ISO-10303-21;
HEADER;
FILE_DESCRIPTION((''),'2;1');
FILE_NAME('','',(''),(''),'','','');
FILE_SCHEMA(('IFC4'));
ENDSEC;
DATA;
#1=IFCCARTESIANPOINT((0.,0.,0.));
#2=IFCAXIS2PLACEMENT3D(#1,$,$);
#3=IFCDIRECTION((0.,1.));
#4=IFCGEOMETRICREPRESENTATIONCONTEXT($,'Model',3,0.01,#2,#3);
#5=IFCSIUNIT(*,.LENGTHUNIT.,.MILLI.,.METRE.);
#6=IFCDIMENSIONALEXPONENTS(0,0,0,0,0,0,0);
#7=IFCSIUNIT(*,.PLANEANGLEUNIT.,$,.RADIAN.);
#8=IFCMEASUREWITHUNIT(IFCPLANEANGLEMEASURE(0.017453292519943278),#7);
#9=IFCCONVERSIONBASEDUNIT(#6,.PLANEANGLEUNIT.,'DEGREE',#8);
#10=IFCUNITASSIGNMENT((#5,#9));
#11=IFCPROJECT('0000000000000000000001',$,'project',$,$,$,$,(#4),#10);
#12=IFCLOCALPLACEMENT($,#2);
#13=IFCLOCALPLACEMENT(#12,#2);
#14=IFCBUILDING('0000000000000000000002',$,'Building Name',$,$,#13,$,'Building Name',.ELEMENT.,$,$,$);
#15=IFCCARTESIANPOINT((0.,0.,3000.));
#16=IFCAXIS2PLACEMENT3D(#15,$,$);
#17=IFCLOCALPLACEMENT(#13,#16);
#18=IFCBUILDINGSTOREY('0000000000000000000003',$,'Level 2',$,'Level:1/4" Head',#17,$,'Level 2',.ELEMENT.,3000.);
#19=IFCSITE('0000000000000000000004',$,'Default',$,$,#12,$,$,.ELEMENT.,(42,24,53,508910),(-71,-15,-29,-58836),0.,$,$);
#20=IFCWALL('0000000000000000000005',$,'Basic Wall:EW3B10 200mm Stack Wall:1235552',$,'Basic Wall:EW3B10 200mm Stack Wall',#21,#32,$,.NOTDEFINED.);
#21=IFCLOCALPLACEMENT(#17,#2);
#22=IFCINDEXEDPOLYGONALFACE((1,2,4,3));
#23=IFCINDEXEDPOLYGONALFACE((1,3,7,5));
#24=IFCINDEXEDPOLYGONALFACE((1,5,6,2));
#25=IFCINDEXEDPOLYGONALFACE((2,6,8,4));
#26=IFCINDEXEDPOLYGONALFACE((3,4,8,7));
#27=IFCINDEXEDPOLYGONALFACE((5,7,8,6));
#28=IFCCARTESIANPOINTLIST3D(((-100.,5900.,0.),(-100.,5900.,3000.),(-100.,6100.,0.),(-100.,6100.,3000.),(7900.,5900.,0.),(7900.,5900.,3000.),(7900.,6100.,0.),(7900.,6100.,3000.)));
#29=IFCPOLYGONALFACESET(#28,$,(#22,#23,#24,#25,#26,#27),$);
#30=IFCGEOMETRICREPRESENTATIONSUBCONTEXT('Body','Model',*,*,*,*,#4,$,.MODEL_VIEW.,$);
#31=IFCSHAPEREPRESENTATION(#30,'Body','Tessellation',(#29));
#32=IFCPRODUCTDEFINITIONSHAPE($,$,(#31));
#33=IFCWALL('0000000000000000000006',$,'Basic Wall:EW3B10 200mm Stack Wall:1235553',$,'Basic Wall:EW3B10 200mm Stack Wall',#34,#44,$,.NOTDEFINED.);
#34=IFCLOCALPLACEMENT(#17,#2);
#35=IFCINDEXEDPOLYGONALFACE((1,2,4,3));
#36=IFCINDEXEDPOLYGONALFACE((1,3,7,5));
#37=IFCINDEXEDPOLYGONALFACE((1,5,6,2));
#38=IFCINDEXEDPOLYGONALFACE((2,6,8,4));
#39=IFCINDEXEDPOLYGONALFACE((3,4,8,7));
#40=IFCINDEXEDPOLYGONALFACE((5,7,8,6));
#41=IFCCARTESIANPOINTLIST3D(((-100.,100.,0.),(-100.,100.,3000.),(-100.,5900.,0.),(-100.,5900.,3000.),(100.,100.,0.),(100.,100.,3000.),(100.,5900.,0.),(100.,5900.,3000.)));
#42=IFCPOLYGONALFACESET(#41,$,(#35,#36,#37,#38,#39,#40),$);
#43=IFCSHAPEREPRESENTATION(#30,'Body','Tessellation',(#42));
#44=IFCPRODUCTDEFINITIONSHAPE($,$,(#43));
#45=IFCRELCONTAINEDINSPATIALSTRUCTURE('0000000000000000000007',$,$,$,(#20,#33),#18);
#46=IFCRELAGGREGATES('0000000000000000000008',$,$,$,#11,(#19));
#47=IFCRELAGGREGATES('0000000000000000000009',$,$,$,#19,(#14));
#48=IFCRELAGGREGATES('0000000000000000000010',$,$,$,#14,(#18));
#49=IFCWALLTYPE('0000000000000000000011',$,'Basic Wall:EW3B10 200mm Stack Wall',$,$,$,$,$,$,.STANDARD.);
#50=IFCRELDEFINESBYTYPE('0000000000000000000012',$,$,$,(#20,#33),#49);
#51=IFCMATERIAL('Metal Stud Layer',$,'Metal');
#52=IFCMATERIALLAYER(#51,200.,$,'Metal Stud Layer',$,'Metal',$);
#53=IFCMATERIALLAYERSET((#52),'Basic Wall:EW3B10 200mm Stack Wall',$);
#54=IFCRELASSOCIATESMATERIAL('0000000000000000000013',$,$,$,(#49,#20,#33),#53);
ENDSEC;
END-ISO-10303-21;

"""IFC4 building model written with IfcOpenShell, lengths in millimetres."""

from ifc_helpers import new_model, entity, si_unit, converted_unit, direction, frame, frame_2d, origin, place, context, subcontext, project, spatial, rectangle, extrude, material, layer, layer_set, layer_usage, type_object, element, save


model = new_model("IFC4")

# Units and contexts
model_context = context("Model", 3, precision=0.01, world=origin(), true_north=direction((0.0, 1.0)))
body_context = subcontext(model_context, "Body", "Model", "MODEL_VIEW")
ifc_project = project(units=[si_unit("LENGTHUNIT", "METRE", prefix="MILLI"), converted_unit("PLANEANGLEUNIT", "DEGREE", entity("IfcPlaneAngleMeasure", 0.017453292519943278), si_unit("PLANEANGLEUNIT", "RADIAN"), dimensions=[0, 0, 0, 0, 0, 0, 0])], contexts=[model_context])

# Site, building, storey
site_placement = place(None, origin())
site = spatial("IfcSite", under=ifc_project, at=site_placement, Name="Default", CompositionType="ELEMENT", RefLatitude=(42, 24, 53, 508910), RefLongitude=(-71, -15, -29, -58836), RefElevation=0.0)
building_placement = place(site_placement, origin())
building = spatial("IfcBuilding", under=site, at=building_placement, Name="Building Name", LongName="Building Name", CompositionType="ELEMENT")
storey_placement = place(building_placement, frame((0.0, 0.0, 3000.0)))
storey = spatial("IfcBuildingStorey", under=building, at=storey_placement, Name="Level 2", ObjectType="Level:1/4\" Head", LongName="Level 2", CompositionType="ELEMENT", Elevation=3000.0)

# Shared definitions
ifc_material_1 = material(Name="Metal Stud Layer", Category="Metal")
ifc_layer_1 = layer(ifc_material_1, 200.0, Name="Metal Stud Layer", Category="Metal")
ifc_layer_set_1 = layer_set([ifc_layer_1], Name="Basic Wall:EW3B10 200mm Stack Wall")
wall_type = type_object("IfcWallType", Name="Basic Wall:EW3B10 200mm Stack Wall", PredefinedType="STANDARD", material=ifc_layer_set_1)

# Walls
ifc_layer_usage_1 = layer_usage(ifc_layer_set_1, "AXIS2", "NEGATIVE", 100.0)
wall_1_placement = place(storey_placement, frame((7900.0, 6000.0, 0.0), z_axis=(0.0, 0.0, 1.0), x_axis=(-1.0, 0.0, 0.0)))
element("IfcWall", 1, at=wall_1_placement, inside=storey, type_object=wall_type, material=ifc_layer_usage_1, Name="Basic Wall:EW3B10 200mm Stack Wall:1235552", ObjectType="Basic Wall:EW3B10 200mm Stack Wall", PredefinedType="NOTDEFINED", context=body_context, shape_type="SweptSolid", body=[
    extrude(rectangle(XDim=8000.0, YDim=200.0, at=frame_2d((4000.0, 0.0), x_axis=(-1.0, 0.0))), origin(), (0.0, 0.0, 1.0), 3000.0),
])
ifc_layer_usage_2 = layer_usage(ifc_layer_set_1, "AXIS2", "NEGATIVE", 100.0)
wall_2_placement = place(storey_placement, frame((0.0, 5900.0, 0.0), z_axis=(0.0, 0.0, 1.0), x_axis=(0.0, -1.0, 0.0)))
element("IfcWall", 2, at=wall_2_placement, inside=storey, type_object=wall_type, material=ifc_layer_usage_2, Name="Basic Wall:EW3B10 200mm Stack Wall:1235553", ObjectType="Basic Wall:EW3B10 200mm Stack Wall", PredefinedType="NOTDEFINED", context=body_context, shape_type="SweptSolid", body=[
    extrude(rectangle(XDim=5800.0, YDim=200.0, at=frame_2d((2900.0, 0.0), x_axis=(-1.0, 0.0))), origin(), (0.0, 0.0, 1.0), 3000.0),
])

save(model, "model.ifc")
